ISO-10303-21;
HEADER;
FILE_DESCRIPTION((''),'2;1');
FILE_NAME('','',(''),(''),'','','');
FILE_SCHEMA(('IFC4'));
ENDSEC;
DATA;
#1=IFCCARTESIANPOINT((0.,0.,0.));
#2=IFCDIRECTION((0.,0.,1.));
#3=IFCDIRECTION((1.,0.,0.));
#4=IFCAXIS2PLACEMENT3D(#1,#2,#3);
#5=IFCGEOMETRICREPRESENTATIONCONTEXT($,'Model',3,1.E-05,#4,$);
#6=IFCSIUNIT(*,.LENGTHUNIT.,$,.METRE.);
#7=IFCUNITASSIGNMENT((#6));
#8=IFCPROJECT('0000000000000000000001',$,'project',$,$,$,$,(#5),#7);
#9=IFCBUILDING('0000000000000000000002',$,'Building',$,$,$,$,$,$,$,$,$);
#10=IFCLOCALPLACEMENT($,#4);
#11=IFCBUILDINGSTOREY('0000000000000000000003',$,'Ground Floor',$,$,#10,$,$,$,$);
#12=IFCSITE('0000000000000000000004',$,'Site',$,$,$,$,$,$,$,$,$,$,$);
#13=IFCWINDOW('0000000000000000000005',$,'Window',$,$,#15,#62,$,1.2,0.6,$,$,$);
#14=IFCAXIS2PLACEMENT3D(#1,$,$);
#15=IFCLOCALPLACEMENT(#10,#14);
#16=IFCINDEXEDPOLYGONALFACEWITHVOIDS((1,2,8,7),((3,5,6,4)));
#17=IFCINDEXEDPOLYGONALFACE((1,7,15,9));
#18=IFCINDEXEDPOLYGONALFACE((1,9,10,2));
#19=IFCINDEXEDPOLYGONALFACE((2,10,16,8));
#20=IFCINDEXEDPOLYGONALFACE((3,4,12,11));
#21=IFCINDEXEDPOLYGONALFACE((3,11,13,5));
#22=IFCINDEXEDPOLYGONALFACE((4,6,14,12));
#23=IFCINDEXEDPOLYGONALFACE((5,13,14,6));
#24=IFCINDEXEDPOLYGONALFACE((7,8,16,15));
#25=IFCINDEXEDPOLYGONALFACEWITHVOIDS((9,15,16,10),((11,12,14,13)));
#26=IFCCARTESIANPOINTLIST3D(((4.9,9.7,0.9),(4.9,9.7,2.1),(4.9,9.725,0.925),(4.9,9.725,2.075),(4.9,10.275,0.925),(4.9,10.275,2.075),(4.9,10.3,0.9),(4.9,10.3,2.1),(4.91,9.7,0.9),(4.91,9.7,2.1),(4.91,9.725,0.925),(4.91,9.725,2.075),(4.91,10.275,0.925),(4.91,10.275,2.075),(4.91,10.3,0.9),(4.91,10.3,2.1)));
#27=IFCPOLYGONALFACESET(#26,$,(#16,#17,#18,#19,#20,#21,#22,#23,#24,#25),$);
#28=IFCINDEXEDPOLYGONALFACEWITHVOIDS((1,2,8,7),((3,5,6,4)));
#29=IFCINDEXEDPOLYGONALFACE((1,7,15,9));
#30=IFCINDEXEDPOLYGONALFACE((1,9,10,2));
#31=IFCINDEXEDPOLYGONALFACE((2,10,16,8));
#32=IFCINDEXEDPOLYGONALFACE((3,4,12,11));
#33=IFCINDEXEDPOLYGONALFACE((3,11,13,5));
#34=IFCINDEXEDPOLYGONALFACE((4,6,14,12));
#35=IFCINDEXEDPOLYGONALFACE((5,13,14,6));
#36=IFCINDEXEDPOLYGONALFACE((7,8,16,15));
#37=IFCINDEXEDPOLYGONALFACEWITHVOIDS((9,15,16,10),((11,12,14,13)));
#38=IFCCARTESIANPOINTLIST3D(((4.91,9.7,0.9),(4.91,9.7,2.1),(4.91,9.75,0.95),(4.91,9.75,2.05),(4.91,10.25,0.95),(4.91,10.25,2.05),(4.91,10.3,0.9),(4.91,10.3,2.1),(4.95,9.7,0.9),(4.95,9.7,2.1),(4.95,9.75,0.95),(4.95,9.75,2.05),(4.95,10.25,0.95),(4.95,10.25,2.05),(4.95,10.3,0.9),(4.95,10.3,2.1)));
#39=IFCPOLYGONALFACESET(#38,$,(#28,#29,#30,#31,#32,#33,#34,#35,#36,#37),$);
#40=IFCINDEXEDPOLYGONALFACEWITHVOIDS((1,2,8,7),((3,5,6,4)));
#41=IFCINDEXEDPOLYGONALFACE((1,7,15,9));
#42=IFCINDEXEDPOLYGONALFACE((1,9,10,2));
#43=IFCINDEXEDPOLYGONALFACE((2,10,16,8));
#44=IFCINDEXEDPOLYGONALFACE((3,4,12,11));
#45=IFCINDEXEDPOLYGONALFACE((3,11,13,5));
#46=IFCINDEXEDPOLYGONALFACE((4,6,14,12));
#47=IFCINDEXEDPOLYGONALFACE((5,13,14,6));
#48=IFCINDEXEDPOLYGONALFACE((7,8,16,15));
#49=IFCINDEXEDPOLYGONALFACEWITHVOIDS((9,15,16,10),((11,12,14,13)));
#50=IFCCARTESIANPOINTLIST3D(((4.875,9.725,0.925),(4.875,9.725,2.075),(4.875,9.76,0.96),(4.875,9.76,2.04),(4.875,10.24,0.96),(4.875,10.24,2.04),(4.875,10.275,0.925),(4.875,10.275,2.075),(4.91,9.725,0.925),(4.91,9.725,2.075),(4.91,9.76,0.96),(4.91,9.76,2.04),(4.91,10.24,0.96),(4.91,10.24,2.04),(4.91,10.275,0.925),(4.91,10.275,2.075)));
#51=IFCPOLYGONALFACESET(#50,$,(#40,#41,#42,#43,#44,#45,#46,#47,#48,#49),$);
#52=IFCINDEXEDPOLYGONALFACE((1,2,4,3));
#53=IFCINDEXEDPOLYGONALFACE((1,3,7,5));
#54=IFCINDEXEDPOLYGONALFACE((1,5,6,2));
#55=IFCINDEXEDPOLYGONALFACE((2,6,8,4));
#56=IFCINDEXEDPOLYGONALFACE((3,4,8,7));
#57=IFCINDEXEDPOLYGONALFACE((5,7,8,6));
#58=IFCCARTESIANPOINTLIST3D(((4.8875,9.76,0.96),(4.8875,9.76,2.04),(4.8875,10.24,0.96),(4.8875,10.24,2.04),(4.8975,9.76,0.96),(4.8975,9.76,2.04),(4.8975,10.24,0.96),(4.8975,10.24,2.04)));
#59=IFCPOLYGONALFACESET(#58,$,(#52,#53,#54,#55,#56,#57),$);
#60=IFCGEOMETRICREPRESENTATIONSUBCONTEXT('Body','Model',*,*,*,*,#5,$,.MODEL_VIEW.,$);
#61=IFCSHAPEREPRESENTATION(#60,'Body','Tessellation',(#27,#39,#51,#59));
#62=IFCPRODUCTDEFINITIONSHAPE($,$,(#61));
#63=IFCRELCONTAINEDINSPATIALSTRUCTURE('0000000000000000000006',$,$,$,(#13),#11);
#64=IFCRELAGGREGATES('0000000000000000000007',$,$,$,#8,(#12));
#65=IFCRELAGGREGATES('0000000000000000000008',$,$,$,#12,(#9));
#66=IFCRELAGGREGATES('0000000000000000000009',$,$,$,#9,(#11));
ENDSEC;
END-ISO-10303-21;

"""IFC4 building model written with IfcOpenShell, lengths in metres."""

from ifc_helpers import new_model, si_unit, frame, origin_with_axes, place, context, subcontext, project, spatial, line, indexed_curve, outline, extrude, element, save


model = new_model("IFC4")

# Units and contexts
model_context = context("Model", 3, precision=1e-05, world=origin_with_axes())
body_context = subcontext(model_context, "Body", "Model", "MODEL_VIEW")
ifc_project = project(units=[si_unit("LENGTHUNIT", "METRE")], contexts=[model_context])

# Site, building, storey
site = spatial("IfcSite", under=ifc_project, Name="Site")
building = spatial("IfcBuilding", under=site, Name="Building")
storey_placement = place(None, origin_with_axes())
storey = spatial("IfcBuildingStorey", under=building, at=storey_placement, Name="Ground Floor")

# Window
window_1_placement = place(storey_placement, frame((5.0, 9.7, 0.9), z_axis=(0.0, 0.0, 1.0), x_axis=(0.0, 1.0, 0.0)))
element("IfcWindow", 1, at=window_1_placement, inside=storey, Name="Window", OverallHeight=1.2, OverallWidth=0.6, context=body_context, shape_type="SweptSolid", body=[
    extrude(outline(indexed_curve([(0.0, 0.0), (0.6, 0.0), (0.6, 1.2), (0.0, 1.2)], segments=[line(1, 2, 3, 4, 1)]), holes=[indexed_curve([(0.025, 0.025), (0.575, 0.025), (0.575, 1.175), (0.025, 1.175)], segments=[line(1, 2, 3, 4, 1)])]), frame((0.0, 0.09, 0.0), z_axis=(0.0, -1.0, 0.0), x_axis=(1.0, 0.0, 0.0)), (0.0, 0.0, -1.0), 0.01),
    extrude(outline(indexed_curve([(0.0, 0.0), (0.6, 0.0), (0.6, 1.2), (0.0, 1.2)], segments=[line(1, 2, 3, 4, 1)]), holes=[indexed_curve([(0.05, 0.05), (0.55, 0.05), (0.55, 1.15), (0.05, 1.15)], segments=[line(1, 2, 3, 4, 1)])]), frame((0.0, 0.05, 0.0), z_axis=(0.0, -1.0, 0.0), x_axis=(1.0, 0.0, 0.0)), (0.0, 0.0, -1.0), 0.04),
    extrude(outline(indexed_curve([(0.0, 0.0), (0.55, 0.0), (0.55, 1.15), (0.0, 1.15)], segments=[line(1, 2, 3, 4, 1)]), holes=[indexed_curve([(0.035, 0.035), (0.515, 0.035), (0.515, 1.115), (0.035, 1.115)], segments=[line(1, 2, 3, 4, 1)])]), frame((0.025, 0.09, 0.025), z_axis=(0.0, -1.0, 0.0), x_axis=(1.0, 0.0, 0.0)), (0.0, 0.0, -1.0), 0.035),
    extrude(outline(indexed_curve([(0.035, 0.035), (0.515, 0.035), (0.515, 1.115), (0.035, 1.115)], segments=[line(1, 2, 3, 4, 1)])), frame((0.025, 0.1025, 0.025), z_axis=(0.0, -1.0, 0.0), x_axis=(1.0, 0.0, 0.0)), (0.0, 0.0, -1.0), 0.01),
])

save(model, "model.ifc")
